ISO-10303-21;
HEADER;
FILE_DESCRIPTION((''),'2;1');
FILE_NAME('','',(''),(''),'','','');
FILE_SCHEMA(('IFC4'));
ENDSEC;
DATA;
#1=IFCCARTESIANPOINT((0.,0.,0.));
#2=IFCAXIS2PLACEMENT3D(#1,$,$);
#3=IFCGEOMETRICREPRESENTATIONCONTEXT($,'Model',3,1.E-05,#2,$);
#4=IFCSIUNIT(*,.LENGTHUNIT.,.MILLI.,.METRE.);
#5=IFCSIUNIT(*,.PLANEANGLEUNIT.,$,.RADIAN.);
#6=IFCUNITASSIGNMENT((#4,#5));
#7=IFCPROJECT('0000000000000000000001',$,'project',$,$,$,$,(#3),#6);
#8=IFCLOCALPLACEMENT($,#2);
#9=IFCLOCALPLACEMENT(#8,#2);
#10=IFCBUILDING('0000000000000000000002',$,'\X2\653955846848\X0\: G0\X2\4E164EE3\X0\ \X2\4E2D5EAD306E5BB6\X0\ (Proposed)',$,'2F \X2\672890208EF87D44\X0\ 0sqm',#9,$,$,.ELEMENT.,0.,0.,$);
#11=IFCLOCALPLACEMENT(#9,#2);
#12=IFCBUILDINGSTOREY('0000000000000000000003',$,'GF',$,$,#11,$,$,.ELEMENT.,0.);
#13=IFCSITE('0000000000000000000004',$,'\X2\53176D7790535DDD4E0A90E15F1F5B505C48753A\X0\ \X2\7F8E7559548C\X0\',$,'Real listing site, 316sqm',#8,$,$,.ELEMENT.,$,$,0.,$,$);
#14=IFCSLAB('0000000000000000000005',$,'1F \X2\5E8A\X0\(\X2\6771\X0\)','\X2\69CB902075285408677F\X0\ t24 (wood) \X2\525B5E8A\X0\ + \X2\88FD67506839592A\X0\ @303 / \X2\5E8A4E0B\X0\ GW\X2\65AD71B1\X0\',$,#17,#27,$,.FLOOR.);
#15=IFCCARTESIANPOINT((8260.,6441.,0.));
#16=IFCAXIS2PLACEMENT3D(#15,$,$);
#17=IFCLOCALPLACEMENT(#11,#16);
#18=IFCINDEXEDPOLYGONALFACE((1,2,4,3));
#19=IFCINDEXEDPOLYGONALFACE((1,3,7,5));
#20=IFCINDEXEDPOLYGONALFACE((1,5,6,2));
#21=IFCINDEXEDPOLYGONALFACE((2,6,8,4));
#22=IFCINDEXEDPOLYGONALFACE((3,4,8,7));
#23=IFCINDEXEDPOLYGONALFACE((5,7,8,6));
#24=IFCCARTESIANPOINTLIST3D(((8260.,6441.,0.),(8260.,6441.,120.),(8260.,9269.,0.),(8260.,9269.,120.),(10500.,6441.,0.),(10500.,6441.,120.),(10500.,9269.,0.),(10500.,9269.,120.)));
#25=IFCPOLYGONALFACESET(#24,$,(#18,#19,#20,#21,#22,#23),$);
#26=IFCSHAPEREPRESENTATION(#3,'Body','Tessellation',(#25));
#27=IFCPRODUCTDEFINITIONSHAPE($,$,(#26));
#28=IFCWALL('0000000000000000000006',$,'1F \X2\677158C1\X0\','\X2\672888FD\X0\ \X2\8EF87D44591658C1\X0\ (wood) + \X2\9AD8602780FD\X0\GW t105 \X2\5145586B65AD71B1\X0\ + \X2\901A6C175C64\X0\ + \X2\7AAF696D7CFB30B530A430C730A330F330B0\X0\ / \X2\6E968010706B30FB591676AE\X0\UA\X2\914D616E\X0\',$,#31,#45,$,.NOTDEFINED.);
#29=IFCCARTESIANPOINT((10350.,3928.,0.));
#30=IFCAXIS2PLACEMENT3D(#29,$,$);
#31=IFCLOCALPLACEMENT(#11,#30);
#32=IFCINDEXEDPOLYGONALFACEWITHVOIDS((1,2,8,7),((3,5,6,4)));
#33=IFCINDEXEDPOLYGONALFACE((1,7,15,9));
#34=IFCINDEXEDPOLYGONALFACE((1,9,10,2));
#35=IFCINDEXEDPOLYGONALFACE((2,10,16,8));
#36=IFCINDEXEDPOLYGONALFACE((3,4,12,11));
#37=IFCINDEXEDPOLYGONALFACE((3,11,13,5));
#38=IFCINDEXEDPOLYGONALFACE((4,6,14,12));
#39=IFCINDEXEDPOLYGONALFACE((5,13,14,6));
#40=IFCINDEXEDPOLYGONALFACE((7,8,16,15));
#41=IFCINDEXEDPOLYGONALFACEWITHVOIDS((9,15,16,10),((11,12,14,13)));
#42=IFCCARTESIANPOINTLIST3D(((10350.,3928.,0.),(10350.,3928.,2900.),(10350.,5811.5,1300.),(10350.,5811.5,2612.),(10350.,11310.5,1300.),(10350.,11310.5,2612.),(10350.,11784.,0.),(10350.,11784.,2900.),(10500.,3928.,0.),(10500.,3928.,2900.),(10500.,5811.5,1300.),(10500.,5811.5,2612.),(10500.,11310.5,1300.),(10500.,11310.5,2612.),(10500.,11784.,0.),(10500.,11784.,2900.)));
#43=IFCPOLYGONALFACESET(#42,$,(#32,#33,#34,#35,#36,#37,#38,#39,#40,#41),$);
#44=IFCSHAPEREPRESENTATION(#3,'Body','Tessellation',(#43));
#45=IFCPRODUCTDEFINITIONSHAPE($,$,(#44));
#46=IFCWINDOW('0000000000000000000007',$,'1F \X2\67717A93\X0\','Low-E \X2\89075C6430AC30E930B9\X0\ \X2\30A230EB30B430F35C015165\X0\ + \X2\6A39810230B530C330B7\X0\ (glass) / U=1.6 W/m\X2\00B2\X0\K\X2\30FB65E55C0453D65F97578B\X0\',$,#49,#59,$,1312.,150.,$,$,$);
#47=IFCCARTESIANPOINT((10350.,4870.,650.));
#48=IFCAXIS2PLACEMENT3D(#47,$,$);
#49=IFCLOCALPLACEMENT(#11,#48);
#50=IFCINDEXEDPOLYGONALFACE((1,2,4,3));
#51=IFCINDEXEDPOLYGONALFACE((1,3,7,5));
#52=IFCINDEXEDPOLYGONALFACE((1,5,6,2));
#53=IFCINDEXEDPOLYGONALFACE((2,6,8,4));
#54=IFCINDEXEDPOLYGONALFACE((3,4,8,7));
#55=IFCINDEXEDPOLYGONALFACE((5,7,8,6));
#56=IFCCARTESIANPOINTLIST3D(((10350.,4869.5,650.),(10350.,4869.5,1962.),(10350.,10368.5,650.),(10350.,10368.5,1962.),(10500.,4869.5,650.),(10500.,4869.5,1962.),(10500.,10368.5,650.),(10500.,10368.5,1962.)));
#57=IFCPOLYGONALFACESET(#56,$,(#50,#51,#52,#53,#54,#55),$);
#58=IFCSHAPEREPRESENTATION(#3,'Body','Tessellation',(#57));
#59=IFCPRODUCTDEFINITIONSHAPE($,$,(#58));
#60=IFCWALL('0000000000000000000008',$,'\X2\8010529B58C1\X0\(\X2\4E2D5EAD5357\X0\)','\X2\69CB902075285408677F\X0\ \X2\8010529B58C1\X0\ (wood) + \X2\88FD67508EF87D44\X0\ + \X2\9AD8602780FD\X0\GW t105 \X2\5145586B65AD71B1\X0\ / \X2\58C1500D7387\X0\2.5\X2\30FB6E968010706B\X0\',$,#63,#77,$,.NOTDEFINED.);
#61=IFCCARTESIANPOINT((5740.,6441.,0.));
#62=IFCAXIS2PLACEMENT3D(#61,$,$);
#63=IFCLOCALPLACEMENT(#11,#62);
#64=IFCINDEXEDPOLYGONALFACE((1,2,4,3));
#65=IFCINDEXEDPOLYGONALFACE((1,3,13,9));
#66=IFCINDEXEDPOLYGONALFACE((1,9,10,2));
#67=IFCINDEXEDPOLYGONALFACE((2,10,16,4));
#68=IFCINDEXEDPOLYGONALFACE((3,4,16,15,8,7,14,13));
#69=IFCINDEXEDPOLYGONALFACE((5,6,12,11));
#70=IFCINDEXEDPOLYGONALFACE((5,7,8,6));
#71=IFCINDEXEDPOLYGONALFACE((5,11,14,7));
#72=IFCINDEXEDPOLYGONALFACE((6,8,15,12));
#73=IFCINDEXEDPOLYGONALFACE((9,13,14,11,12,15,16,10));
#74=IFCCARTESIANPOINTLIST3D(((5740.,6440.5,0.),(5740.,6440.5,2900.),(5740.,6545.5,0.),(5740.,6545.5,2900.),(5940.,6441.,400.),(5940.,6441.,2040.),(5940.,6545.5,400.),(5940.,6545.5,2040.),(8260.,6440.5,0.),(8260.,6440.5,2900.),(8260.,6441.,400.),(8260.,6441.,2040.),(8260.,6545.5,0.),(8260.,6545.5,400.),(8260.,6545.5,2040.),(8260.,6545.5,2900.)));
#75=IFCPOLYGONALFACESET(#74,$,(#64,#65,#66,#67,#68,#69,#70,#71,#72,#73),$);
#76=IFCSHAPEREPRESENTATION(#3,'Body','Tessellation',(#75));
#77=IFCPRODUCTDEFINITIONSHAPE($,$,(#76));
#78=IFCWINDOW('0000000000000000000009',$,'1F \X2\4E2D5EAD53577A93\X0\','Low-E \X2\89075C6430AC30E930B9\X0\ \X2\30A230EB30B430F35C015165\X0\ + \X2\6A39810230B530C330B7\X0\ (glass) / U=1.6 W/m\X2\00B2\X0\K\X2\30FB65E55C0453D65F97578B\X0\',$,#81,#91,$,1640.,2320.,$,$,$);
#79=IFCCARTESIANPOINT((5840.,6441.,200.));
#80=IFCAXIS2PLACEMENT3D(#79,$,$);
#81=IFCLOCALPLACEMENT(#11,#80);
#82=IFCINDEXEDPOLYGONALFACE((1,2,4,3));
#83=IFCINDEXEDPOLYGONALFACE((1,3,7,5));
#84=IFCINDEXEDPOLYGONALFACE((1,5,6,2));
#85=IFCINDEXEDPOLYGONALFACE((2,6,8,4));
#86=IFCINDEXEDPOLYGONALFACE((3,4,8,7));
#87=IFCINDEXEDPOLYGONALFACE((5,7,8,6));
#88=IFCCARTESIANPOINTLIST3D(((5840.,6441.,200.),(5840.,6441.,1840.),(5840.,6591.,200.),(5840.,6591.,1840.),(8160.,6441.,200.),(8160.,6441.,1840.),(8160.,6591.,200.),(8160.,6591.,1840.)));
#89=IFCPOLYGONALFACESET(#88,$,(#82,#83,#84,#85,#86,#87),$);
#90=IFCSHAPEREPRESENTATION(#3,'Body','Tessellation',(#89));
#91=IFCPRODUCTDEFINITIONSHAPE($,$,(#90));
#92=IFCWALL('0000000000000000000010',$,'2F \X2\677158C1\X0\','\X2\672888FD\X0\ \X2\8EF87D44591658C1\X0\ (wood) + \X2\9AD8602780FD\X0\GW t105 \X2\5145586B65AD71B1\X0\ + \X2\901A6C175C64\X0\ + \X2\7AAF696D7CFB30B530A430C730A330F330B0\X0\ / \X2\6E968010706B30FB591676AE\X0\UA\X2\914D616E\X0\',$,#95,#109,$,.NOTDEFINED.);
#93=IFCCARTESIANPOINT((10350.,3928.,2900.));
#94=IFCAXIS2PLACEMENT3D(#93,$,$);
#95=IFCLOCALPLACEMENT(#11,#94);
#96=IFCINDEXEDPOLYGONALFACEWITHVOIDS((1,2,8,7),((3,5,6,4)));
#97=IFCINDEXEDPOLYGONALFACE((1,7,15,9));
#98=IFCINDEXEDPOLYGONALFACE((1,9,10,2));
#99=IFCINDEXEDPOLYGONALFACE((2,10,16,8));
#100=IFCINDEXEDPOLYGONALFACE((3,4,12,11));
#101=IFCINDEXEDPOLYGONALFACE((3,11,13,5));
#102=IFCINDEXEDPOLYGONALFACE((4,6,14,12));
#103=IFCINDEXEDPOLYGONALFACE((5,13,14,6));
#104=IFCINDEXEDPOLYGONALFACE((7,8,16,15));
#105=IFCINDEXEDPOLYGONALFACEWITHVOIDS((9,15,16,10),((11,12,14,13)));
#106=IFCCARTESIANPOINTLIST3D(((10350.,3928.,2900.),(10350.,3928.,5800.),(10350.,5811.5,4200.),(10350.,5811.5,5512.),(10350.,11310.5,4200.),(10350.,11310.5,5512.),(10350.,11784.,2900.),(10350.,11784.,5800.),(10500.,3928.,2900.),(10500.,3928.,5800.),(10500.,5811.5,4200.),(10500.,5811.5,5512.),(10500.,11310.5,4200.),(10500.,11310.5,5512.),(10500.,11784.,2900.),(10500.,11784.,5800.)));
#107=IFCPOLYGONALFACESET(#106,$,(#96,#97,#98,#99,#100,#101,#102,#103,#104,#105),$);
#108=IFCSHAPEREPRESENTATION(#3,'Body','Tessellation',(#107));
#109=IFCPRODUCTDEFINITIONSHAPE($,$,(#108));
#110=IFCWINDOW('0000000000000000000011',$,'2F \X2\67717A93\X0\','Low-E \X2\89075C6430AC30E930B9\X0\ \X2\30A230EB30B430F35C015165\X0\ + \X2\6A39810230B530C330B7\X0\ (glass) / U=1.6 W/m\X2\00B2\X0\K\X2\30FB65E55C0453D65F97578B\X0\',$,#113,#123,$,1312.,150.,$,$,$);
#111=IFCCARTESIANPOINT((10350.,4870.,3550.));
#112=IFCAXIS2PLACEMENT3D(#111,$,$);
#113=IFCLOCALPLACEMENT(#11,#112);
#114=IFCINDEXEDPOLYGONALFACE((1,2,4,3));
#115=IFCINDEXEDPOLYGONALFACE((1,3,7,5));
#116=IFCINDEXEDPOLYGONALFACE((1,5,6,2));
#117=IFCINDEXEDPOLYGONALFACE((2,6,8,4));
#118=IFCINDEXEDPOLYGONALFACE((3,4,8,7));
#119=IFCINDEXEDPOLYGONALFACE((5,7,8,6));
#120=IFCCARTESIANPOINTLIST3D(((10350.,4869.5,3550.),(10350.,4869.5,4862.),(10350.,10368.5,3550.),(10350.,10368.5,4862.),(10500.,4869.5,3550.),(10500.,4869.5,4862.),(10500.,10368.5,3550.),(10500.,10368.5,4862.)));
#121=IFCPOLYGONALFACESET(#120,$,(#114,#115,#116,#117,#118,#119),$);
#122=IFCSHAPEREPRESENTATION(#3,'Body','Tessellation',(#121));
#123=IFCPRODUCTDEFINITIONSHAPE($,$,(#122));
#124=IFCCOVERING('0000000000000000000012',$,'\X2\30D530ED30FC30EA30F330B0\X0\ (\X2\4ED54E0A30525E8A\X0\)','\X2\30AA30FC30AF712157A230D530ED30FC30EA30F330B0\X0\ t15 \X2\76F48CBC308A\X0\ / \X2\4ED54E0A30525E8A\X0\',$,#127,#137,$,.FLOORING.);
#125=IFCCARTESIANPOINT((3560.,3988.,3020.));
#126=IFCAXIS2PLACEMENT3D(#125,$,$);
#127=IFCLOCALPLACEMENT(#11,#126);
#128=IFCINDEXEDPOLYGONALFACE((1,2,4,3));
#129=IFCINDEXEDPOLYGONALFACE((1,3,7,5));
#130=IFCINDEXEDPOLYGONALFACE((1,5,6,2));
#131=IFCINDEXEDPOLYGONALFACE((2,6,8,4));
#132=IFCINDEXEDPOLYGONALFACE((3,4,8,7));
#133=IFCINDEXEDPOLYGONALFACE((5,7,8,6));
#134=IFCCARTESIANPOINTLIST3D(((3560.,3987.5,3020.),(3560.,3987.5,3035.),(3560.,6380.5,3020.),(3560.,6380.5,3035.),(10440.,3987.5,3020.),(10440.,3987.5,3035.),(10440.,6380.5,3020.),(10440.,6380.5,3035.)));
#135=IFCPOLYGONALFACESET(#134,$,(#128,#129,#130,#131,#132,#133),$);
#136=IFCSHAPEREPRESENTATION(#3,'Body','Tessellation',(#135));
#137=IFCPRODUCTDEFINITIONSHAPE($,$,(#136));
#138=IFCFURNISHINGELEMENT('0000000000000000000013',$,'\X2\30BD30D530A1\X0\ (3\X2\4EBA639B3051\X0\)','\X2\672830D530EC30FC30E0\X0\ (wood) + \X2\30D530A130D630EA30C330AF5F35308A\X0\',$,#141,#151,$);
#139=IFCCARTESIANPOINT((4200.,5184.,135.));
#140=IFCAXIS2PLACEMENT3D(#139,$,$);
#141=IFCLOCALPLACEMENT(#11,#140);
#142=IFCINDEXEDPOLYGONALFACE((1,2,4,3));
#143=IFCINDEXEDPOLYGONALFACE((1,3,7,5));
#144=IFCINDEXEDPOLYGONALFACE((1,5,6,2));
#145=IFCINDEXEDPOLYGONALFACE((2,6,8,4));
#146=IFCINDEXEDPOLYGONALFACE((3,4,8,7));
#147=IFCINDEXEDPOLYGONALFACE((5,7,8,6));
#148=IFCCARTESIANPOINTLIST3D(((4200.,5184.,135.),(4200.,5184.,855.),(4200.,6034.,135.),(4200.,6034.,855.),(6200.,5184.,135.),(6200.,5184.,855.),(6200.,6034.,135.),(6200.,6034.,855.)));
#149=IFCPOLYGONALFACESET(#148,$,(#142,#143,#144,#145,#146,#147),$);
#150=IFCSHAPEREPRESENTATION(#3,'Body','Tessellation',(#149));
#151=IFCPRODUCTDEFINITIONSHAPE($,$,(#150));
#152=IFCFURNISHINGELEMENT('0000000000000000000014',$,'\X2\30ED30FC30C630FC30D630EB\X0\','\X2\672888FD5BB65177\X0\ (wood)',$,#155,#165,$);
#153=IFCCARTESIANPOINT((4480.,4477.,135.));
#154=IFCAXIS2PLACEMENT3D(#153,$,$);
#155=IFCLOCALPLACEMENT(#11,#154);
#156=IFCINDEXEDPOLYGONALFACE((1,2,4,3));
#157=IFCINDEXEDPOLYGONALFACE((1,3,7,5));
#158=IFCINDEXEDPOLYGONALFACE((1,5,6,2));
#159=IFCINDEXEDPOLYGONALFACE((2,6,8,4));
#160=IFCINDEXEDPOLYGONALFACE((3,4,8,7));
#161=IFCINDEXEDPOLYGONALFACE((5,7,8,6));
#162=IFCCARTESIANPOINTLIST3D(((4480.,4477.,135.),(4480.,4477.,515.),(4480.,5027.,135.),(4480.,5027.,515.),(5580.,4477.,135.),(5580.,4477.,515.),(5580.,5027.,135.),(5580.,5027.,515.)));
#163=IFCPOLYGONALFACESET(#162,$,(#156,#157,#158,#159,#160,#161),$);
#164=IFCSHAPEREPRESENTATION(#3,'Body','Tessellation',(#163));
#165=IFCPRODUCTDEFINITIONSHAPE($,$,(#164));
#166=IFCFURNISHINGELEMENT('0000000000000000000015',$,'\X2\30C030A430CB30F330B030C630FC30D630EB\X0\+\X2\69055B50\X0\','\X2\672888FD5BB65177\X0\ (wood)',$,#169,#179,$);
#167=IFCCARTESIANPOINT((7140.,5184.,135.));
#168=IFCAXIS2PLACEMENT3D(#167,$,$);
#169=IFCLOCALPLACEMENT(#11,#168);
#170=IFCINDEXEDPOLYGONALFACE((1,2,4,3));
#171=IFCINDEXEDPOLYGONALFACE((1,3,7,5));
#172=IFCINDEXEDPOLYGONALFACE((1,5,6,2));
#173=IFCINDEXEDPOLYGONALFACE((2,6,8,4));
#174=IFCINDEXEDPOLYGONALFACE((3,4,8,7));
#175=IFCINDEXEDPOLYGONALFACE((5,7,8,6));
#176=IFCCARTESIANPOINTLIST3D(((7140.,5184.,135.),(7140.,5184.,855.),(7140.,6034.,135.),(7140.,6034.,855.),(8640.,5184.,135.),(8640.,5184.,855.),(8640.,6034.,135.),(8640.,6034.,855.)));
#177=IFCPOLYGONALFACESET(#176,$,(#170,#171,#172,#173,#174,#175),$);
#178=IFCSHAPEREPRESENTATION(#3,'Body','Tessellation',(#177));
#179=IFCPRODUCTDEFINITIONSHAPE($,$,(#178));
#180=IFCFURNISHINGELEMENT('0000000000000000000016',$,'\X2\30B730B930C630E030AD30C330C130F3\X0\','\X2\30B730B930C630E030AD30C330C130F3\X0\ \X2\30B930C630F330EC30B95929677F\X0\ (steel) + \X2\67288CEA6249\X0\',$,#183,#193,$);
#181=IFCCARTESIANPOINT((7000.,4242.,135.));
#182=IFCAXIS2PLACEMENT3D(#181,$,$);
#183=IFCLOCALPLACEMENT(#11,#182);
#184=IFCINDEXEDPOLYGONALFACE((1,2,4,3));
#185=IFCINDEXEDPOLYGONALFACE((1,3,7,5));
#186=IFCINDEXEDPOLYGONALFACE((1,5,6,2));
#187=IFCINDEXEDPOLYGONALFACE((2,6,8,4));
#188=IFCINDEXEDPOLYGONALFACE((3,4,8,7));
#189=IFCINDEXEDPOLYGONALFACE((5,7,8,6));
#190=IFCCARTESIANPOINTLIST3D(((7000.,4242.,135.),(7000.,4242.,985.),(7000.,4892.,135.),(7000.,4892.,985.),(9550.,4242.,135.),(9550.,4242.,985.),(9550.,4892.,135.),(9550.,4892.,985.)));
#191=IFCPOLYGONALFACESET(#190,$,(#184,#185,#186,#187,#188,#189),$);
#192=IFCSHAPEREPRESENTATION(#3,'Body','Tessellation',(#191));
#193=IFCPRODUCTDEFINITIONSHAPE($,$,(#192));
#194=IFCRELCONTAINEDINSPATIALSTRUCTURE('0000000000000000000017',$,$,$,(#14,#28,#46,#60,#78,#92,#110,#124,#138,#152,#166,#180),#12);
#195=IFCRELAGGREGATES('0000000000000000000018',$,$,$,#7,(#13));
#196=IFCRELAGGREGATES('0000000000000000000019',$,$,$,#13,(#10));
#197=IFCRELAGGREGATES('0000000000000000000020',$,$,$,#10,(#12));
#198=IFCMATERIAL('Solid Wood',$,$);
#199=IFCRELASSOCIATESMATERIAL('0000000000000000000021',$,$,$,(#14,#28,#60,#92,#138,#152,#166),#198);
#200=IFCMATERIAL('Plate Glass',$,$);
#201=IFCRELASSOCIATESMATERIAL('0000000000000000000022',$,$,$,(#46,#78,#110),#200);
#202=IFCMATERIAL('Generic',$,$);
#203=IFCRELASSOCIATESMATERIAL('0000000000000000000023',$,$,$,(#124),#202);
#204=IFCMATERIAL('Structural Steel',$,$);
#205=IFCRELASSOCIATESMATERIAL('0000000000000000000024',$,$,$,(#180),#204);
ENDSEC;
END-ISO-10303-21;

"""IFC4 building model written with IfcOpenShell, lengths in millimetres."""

from ifc_helpers import new_model, si_unit, frame, frame_2d, origin, place, context, project, spatial, rectangle, extrude, material, element, fill, save


model = new_model("IFC4")

# Units and contexts
model_context = context("Model", 3, precision=1e-05, world=origin())
ifc_project = project(units=[si_unit("LENGTHUNIT", "METRE", prefix="MILLI"), si_unit("PLANEANGLEUNIT", "RADIAN")], contexts=[model_context])

# Site, building, storey
site_placement = place(None, origin())
site = spatial("IfcSite", under=ifc_project, at=site_placement, Name="北海道川上郡弟子屈町 美留和", ObjectType="Real listing site, 316sqm", CompositionType="ELEMENT", RefElevation=0.0)
building_placement = place(site_placement, origin())
building = spatial("IfcBuilding", under=site, at=building_placement, Name="改善案: G0世代 中庭の家 (Proposed)", ObjectType="2F 木造軸組 0sqm", CompositionType="ELEMENT", ElevationOfRefHeight=0.0, ElevationOfTerrain=0.0)
storey_placement = place(building_placement, origin())
storey = spatial("IfcBuildingStorey", under=building, at=storey_placement, Name="GF", CompositionType="ELEMENT", Elevation=0.0)

# Slab
ifc_material_1 = material(Name="Solid Wood")
slab_placement = place(storey_placement, frame((8260.0, 6441.0, 0.0)))
element("IfcSlab", 1, at=slab_placement, inside=storey, material=ifc_material_1, Name="1F 床(東)", Description="構造用合板 t24 (wood) 剛床 + 製材根太 @303 / 床下 GW断熱", PredefinedType="FLOOR", context=model_context, shape_type="SweptSolid", body=[
    extrude(rectangle(XDim=2240.0, YDim=2828.0, at=frame_2d((1120.0, 1414.0))), frame((8260.0, 6441.0, 0.0)), (0.0, 0.0, 1.0), 120.0),
])

# Walls, openings, windows
wall_1_placement = place(storey_placement, frame((10350.0, 3928.0, 0.0)))
wall_1 = element("IfcWall", 2, at=wall_1_placement, inside=storey, material=ifc_material_1, Name="1F 東壁", Description="木製 軸組外壁 (wood) + 高性能GW t105 充填断熱 + 通気層 + 窯業系サイディング / 準耐火・外皮UA配慮", PredefinedType="NOTDEFINED", context=model_context, shape_type="SweptSolid", body=[
    extrude(rectangle(XDim=150.0, YDim=7856.0, at=frame_2d((75.0, 3928.0))), frame((10350.0, 3928.0, 0.0)), (0.0, 0.0, 1.0), 2900.0),
])
opening_1_placement = place(storey_placement, frame((10350.0, 4870.0, 650.0)))
opening_1 = element("IfcOpeningElement", 3, at=opening_1_placement, cuts=wall_1, PredefinedType="NOTDEFINED", context=model_context, shape_type="SweptSolid", body=[
    extrude(rectangle(XDim=150.0, YDim=5499.0, at=frame_2d((75.0, 2749.0))), frame((10350.0, 4870.0, 650.0)), (0.0, 0.0, 1.0), 1312.0),
])
ifc_material_2 = material(Name="Plate Glass")
window_1_placement = place(storey_placement, frame((10350.0, 4870.0, 650.0)))
window_1 = element("IfcWindow", 4, at=window_1_placement, inside=storey, material=ifc_material_2, Name="1F 東窓", Description="Low-E 複層ガラス アルゴン封入 + 樹脂サッシ (glass) / U=1.6 W/m²K・日射取得型", OverallHeight=1312.0, OverallWidth=150.0, context=model_context, shape_type="SweptSolid", body=[
    extrude(rectangle(XDim=150.0, YDim=5499.0, at=frame_2d((75.0, 2749.0))), frame((10350.0, 4870.0, 650.0)), (0.0, 0.0, 1.0), 1312.0),
])
fill(opening_1, window_1)
wall_2_placement = place(storey_placement, frame((5740.0, 6441.0, 0.0)))
wall_2 = element("IfcWall", 5, at=wall_2_placement, inside=storey, material=ifc_material_1, Name="耐力壁(中庭南)", Description="構造用合板 耐力壁 (wood) + 製材軸組 + 高性能GW t105 充填断熱 / 壁倍率2.5・準耐火", PredefinedType="NOTDEFINED", context=model_context, shape_type="SweptSolid", body=[
    extrude(rectangle(XDim=2520.0, YDim=105.0, at=frame_2d((1260.0, 52.0))), frame((5740.0, 6441.0, 0.0)), (0.0, 0.0, 1.0), 2900.0),
])
opening_2_placement = place(storey_placement, frame((5840.0, 6441.0, 200.0)))
opening_2 = element("IfcOpeningElement", 6, at=opening_2_placement, cuts=wall_2, PredefinedType="NOTDEFINED", context=model_context, shape_type="SweptSolid", body=[
    extrude(rectangle(XDim=2320.0, YDim=150.0, at=frame_2d((1160.0, 75.0))), frame((5840.0, 6441.0, 200.0)), (0.0, 0.0, 1.0), 1640.0),
])
window_2_placement = place(storey_placement, frame((5840.0, 6441.0, 200.0)))
window_2 = element("IfcWindow", 7, at=window_2_placement, inside=storey, material=ifc_material_2, Name="1F 中庭南窓", Description="Low-E 複層ガラス アルゴン封入 + 樹脂サッシ (glass) / U=1.6 W/m²K・日射取得型", OverallHeight=1640.0, OverallWidth=2320.0, context=model_context, shape_type="SweptSolid", body=[
    extrude(rectangle(XDim=2320.0, YDim=150.0, at=frame_2d((1160.0, 75.0))), frame((5840.0, 6441.0, 200.0)), (0.0, 0.0, 1.0), 1640.0),
])
fill(opening_2, window_2)

# Wall, opening, window
wall_3_placement = place(storey_placement, frame((10350.0, 3928.0, 2900.0)))
wall_3 = element("IfcWall", 8, at=wall_3_placement, inside=storey, material=ifc_material_1, Name="2F 東壁", Description="木製 軸組外壁 (wood) + 高性能GW t105 充填断熱 + 通気層 + 窯業系サイディング / 準耐火・外皮UA配慮", PredefinedType="NOTDEFINED", context=model_context, shape_type="SweptSolid", body=[
    extrude(rectangle(XDim=150.0, YDim=7856.0, at=frame_2d((75.0, 3928.0))), frame((10350.0, 3928.0, 2900.0)), (0.0, 0.0, 1.0), 2900.0),
])
opening_3_placement = place(storey_placement, frame((10350.0, 4870.0, 3550.0)))
opening_3 = element("IfcOpeningElement", 9, at=opening_3_placement, cuts=wall_3, PredefinedType="NOTDEFINED", context=model_context, shape_type="SweptSolid", body=[
    extrude(rectangle(XDim=150.0, YDim=5499.0, at=frame_2d((75.0, 2749.0))), frame((10350.0, 4870.0, 3550.0)), (0.0, 0.0, 1.0), 1312.0),
])
window_3_placement = place(storey_placement, frame((10350.0, 4870.0, 3550.0)))
window_3 = element("IfcWindow", 10, at=window_3_placement, inside=storey, material=ifc_material_2, Name="2F 東窓", Description="Low-E 複層ガラス アルゴン封入 + 樹脂サッシ (glass) / U=1.6 W/m²K・日射取得型", OverallHeight=1312.0, OverallWidth=150.0, context=model_context, shape_type="SweptSolid", body=[
    extrude(rectangle(XDim=150.0, YDim=5499.0, at=frame_2d((75.0, 2749.0))), frame((10350.0, 4870.0, 3550.0)), (0.0, 0.0, 1.0), 1312.0),
])
fill(opening_3, window_3)

# Covering
ifc_material_3 = material(Name="Generic")
covering_placement = place(storey_placement, frame((3560.0, 3988.0, 3020.0)))
element("IfcCovering", 11, at=covering_placement, inside=storey, material=ifc_material_3, Name="フローリング (仕上げ床)", Description="オーク無垢フローリング t15 直貼り / 仕上げ床", PredefinedType="FLOORING", context=model_context, shape_type="SweptSolid", body=[
    extrude(rectangle(XDim=6880.0, YDim=2393.0, at=frame_2d((3440.0, 1196.0))), frame((3560.0, 3988.0, 3020.0)), (0.0, 0.0, 1.0), 15.0),
])

# Furnishing elements
furnishing_1_placement = place(storey_placement, frame((4200.0, 5184.0, 135.0)))
element("IfcFurnishingElement", 12, at=furnishing_1_placement, inside=storey, material=ifc_material_1, Name="ソファ (3人掛け)", Description="木フレーム (wood) + ファブリック張り", context=model_context, shape_type="SweptSolid", body=[
    extrude(rectangle(XDim=2000.0, YDim=850.0, at=frame_2d((1000.0, 425.0))), frame((4200.0, 5184.0, 135.0)), (0.0, 0.0, 1.0), 720.0),
])
furnishing_2_placement = place(storey_placement, frame((4480.0, 4477.0, 135.0)))
element("IfcFurnishingElement", 13, at=furnishing_2_placement, inside=storey, material=ifc_material_1, Name="ローテーブル", Description="木製家具 (wood)", context=model_context, shape_type="SweptSolid", body=[
    extrude(rectangle(XDim=1100.0, YDim=550.0, at=frame_2d((550.0, 275.0))), frame((4480.0, 4477.0, 135.0)), (0.0, 0.0, 1.0), 380.0),
])
furnishing_3_placement = place(storey_placement, frame((7140.0, 5184.0, 135.0)))
element("IfcFurnishingElement", 14, at=furnishing_3_placement, inside=storey, material=ifc_material_1, Name="ダイニングテーブル+椅子", Description="木製家具 (wood)", context=model_context, shape_type="SweptSolid", body=[
    extrude(rectangle(XDim=1500.0, YDim=850.0, at=frame_2d((750.0, 425.0))), frame((7140.0, 5184.0, 135.0)), (0.0, 0.0, 1.0), 720.0),
])
ifc_material_4 = material(Name="Structural Steel")
furnishing_4_placement = place(storey_placement, frame((7000.0, 4242.0, 135.0)))
element("IfcFurnishingElement", 15, at=furnishing_4_placement, inside=storey, material=ifc_material_4, Name="システムキッチン", Description="システムキッチン ステンレス天板 (steel) + 木質扉", context=model_context, shape_type="SweptSolid", body=[
    extrude(rectangle(XDim=2550.0, YDim=650.0, at=frame_2d((1275.0, 325.0))), frame((7000.0, 4242.0, 135.0)), (0.0, 0.0, 1.0), 850.0),
])

save(model, "model.ifc")
